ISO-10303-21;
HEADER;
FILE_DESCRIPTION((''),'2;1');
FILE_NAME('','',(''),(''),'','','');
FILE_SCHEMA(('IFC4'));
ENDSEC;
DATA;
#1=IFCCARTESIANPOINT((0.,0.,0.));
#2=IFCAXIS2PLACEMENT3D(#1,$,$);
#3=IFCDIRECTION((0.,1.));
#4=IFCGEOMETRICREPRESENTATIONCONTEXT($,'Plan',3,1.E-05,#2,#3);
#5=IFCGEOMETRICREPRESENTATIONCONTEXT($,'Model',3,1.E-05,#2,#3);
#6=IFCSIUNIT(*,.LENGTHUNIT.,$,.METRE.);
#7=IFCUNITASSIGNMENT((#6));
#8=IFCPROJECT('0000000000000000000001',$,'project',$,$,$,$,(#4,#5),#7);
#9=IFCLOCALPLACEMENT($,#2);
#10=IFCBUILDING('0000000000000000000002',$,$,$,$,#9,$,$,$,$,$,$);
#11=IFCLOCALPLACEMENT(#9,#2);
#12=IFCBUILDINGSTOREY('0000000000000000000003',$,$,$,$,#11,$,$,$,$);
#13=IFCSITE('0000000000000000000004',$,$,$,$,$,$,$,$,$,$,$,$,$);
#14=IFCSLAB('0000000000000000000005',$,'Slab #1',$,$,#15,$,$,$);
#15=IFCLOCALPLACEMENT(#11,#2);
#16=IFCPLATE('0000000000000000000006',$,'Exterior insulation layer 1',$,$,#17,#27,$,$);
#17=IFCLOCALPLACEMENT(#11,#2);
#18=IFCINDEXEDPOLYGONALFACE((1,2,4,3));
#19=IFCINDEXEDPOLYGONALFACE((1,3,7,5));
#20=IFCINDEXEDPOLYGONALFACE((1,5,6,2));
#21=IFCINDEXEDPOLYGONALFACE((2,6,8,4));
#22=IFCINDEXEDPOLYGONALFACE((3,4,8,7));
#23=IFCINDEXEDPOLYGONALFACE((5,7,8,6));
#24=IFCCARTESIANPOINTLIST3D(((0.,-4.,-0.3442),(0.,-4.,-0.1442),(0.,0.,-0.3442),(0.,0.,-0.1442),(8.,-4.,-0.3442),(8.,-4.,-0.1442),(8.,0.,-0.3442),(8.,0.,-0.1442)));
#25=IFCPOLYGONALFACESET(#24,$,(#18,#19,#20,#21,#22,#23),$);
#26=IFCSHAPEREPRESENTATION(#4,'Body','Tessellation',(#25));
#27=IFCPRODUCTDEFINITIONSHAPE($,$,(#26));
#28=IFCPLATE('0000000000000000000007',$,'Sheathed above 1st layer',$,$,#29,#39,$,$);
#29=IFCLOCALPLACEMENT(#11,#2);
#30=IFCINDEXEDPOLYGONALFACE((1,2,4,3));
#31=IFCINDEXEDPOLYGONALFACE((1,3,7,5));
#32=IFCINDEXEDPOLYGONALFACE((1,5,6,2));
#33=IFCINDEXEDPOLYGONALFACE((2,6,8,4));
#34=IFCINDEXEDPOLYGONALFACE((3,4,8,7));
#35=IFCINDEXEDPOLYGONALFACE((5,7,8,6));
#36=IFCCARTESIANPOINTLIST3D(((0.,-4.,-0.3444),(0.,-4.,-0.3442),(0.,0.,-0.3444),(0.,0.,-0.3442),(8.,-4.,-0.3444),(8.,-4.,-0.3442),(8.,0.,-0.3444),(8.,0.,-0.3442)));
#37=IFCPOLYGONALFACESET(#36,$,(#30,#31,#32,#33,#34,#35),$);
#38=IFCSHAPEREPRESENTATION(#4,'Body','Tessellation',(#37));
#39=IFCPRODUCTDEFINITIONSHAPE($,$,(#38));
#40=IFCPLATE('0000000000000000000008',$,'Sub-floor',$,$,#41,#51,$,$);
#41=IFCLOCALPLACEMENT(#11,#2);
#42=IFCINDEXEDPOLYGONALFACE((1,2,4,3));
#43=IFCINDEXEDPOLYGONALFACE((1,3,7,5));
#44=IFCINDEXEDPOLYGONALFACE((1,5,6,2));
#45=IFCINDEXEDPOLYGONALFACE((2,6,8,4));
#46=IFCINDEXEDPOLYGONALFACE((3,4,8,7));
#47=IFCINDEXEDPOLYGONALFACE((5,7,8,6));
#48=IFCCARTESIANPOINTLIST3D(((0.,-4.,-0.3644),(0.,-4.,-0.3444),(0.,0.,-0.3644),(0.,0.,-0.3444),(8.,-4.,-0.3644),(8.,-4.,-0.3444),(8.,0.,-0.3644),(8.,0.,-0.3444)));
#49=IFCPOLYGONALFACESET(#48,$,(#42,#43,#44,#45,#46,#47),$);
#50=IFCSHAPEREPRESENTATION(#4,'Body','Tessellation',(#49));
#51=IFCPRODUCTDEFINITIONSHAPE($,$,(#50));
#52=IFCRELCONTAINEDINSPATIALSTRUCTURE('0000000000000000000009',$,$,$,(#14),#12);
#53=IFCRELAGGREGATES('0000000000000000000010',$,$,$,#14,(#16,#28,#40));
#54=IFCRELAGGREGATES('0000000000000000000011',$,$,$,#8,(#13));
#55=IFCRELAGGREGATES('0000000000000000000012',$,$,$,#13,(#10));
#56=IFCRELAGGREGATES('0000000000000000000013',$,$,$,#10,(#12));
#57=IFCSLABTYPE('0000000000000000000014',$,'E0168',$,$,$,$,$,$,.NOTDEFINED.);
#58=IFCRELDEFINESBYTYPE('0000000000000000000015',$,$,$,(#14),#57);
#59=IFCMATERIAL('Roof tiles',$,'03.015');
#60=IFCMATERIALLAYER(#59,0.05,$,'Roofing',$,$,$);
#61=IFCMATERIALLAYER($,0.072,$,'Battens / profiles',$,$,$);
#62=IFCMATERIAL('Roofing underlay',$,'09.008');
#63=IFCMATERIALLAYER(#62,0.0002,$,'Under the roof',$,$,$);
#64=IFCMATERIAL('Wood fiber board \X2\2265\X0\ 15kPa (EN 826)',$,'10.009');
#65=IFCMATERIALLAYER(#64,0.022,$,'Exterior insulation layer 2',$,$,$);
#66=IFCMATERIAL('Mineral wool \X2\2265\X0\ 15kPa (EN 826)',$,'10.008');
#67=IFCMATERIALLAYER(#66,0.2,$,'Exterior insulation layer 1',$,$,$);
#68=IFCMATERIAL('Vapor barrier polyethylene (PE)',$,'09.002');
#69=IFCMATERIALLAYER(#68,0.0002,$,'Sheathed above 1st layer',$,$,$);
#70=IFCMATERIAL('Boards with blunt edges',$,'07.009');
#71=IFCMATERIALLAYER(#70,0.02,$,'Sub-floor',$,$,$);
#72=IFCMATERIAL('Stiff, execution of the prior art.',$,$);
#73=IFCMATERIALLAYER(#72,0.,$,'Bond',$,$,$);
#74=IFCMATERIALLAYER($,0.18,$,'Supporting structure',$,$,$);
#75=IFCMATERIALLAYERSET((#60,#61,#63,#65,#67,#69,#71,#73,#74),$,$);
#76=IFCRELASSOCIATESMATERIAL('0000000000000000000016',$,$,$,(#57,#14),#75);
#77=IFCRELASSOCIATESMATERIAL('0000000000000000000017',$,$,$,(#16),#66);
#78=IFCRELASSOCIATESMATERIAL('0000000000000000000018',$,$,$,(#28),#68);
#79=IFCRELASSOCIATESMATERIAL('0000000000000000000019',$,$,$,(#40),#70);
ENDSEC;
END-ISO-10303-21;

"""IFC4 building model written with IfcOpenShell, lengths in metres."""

from ifc_helpers import new_model, si_unit, direction, frame, frame_2d, origin, place, context, project, spatial, rectangle, extrude, material, layer, layer_set, type_object, element, aggregate, save


model = new_model("IFC4")

# Units and contexts
plan_context = context("Plan", 3, precision=1e-05, world=origin(), true_north=direction((0.0, 1.0)))
model_context = context("Model", 3, precision=1e-05, world=origin(), true_north=direction((0.0, 1.0)))
ifc_project = project(units=[si_unit("LENGTHUNIT", "METRE")], contexts=[plan_context, model_context])

# Site, building, storey
site = spatial("IfcSite", under=ifc_project)
building_placement = place(None, origin())
building = spatial("IfcBuilding", under=site, at=building_placement)
storey_placement = place(building_placement, origin())
storey = spatial("IfcBuildingStorey", under=building, at=storey_placement)

# Slab, plates
ifc_material_1 = material(Name="Roof tiles", Category="03.015")
ifc_layer_1 = layer(ifc_material_1, 0.05, Name="Roofing")
ifc_layer_2 = layer(None, 0.072, Name="Battens / profiles")
ifc_material_2 = material(Name="Roofing underlay", Category="09.008")
ifc_layer_3 = layer(ifc_material_2, 0.0002, Name="Under the roof")
ifc_material_3 = material(Name="Wood fiber board ≥ 15kPa (EN 826)", Category="10.009")
ifc_layer_4 = layer(ifc_material_3, 0.022, Name="Exterior insulation layer 2")
ifc_material_4 = material(Name="Mineral wool ≥ 15kPa (EN 826)", Category="10.008")
ifc_layer_5 = layer(ifc_material_4, 0.2, Name="Exterior insulation layer 1")
ifc_material_5 = material(Name="Vapor barrier polyethylene (PE)", Category="09.002")
ifc_layer_6 = layer(ifc_material_5, 0.0002, Name="Sheathed above 1st layer")
ifc_material_6 = material(Name="Boards with blunt edges", Category="07.009")
ifc_layer_7 = layer(ifc_material_6, 0.02, Name="Sub-floor")
ifc_material_7 = material(Name="Stiff, execution of the prior art.")
ifc_layer_8 = layer(ifc_material_7, 0.0, Name="Bond")
ifc_layer_9 = layer(None, 0.18, Name="Supporting structure")
ifc_layer_set = layer_set([ifc_layer_1, ifc_layer_2, ifc_layer_3, ifc_layer_4, ifc_layer_5, ifc_layer_6, ifc_layer_7, ifc_layer_8, ifc_layer_9])
slab_type = type_object("IfcSlabType", Name="E0168", PredefinedType="NOTDEFINED", material=ifc_layer_set)
slab_placement = place(None, frame((0.0, 0.0, 0.0), z_axis=(0.0, 0.0, -1.0), x_axis=(1.0, 0.0, 0.0)))
slab = element("IfcSlab", 1, at=slab_placement, inside=storey, type_object=slab_type, material=ifc_layer_set, Name="Slab #1")
plate_1_placement = place(slab_placement, origin())
plate_1 = element("IfcPlate", 2, at=plate_1_placement, material=ifc_material_4, Name="Exterior insulation layer 1", context=plan_context, shape_type="SweptSolid", body=[
    extrude(rectangle(XDim=8.0, YDim=4.0, at=frame_2d((4.0, 2.0), x_axis=(1.0, 0.0))), frame((0.0, 0.0, 0.1442), z_axis=(0.0, 0.0, 1.0), x_axis=(1.0, 0.0, 0.0)), (0.0, 0.0, 1.0), 0.2),
])
plate_2_placement = place(slab_placement, origin())
plate_2 = element("IfcPlate", 3, at=plate_2_placement, material=ifc_material_5, Name="Sheathed above 1st layer", context=plan_context, shape_type="SweptSolid", body=[
    extrude(rectangle(XDim=8.0, YDim=4.0, at=frame_2d((4.0, 2.0), x_axis=(1.0, 0.0))), frame((0.0, 0.0, 0.3442), z_axis=(0.0, 0.0, 1.0), x_axis=(1.0, 0.0, 0.0)), (0.0, 0.0, 1.0), 0.0002),
])
plate_3_placement = place(slab_placement, origin())
plate_3 = element("IfcPlate", 4, at=plate_3_placement, material=ifc_material_6, Name="Sub-floor", context=plan_context, shape_type="SweptSolid", body=[
    extrude(rectangle(XDim=8.0, YDim=4.0, at=frame_2d((4.0, 2.0), x_axis=(1.0, 0.0))), frame((0.0, 0.0, 0.3444), z_axis=(0.0, 0.0, 1.0), x_axis=(1.0, 0.0, 0.0)), (0.0, 0.0, 1.0), 0.02),
])
aggregate(slab, [plate_1, plate_2, plate_3])

save(model, "model.ifc")
